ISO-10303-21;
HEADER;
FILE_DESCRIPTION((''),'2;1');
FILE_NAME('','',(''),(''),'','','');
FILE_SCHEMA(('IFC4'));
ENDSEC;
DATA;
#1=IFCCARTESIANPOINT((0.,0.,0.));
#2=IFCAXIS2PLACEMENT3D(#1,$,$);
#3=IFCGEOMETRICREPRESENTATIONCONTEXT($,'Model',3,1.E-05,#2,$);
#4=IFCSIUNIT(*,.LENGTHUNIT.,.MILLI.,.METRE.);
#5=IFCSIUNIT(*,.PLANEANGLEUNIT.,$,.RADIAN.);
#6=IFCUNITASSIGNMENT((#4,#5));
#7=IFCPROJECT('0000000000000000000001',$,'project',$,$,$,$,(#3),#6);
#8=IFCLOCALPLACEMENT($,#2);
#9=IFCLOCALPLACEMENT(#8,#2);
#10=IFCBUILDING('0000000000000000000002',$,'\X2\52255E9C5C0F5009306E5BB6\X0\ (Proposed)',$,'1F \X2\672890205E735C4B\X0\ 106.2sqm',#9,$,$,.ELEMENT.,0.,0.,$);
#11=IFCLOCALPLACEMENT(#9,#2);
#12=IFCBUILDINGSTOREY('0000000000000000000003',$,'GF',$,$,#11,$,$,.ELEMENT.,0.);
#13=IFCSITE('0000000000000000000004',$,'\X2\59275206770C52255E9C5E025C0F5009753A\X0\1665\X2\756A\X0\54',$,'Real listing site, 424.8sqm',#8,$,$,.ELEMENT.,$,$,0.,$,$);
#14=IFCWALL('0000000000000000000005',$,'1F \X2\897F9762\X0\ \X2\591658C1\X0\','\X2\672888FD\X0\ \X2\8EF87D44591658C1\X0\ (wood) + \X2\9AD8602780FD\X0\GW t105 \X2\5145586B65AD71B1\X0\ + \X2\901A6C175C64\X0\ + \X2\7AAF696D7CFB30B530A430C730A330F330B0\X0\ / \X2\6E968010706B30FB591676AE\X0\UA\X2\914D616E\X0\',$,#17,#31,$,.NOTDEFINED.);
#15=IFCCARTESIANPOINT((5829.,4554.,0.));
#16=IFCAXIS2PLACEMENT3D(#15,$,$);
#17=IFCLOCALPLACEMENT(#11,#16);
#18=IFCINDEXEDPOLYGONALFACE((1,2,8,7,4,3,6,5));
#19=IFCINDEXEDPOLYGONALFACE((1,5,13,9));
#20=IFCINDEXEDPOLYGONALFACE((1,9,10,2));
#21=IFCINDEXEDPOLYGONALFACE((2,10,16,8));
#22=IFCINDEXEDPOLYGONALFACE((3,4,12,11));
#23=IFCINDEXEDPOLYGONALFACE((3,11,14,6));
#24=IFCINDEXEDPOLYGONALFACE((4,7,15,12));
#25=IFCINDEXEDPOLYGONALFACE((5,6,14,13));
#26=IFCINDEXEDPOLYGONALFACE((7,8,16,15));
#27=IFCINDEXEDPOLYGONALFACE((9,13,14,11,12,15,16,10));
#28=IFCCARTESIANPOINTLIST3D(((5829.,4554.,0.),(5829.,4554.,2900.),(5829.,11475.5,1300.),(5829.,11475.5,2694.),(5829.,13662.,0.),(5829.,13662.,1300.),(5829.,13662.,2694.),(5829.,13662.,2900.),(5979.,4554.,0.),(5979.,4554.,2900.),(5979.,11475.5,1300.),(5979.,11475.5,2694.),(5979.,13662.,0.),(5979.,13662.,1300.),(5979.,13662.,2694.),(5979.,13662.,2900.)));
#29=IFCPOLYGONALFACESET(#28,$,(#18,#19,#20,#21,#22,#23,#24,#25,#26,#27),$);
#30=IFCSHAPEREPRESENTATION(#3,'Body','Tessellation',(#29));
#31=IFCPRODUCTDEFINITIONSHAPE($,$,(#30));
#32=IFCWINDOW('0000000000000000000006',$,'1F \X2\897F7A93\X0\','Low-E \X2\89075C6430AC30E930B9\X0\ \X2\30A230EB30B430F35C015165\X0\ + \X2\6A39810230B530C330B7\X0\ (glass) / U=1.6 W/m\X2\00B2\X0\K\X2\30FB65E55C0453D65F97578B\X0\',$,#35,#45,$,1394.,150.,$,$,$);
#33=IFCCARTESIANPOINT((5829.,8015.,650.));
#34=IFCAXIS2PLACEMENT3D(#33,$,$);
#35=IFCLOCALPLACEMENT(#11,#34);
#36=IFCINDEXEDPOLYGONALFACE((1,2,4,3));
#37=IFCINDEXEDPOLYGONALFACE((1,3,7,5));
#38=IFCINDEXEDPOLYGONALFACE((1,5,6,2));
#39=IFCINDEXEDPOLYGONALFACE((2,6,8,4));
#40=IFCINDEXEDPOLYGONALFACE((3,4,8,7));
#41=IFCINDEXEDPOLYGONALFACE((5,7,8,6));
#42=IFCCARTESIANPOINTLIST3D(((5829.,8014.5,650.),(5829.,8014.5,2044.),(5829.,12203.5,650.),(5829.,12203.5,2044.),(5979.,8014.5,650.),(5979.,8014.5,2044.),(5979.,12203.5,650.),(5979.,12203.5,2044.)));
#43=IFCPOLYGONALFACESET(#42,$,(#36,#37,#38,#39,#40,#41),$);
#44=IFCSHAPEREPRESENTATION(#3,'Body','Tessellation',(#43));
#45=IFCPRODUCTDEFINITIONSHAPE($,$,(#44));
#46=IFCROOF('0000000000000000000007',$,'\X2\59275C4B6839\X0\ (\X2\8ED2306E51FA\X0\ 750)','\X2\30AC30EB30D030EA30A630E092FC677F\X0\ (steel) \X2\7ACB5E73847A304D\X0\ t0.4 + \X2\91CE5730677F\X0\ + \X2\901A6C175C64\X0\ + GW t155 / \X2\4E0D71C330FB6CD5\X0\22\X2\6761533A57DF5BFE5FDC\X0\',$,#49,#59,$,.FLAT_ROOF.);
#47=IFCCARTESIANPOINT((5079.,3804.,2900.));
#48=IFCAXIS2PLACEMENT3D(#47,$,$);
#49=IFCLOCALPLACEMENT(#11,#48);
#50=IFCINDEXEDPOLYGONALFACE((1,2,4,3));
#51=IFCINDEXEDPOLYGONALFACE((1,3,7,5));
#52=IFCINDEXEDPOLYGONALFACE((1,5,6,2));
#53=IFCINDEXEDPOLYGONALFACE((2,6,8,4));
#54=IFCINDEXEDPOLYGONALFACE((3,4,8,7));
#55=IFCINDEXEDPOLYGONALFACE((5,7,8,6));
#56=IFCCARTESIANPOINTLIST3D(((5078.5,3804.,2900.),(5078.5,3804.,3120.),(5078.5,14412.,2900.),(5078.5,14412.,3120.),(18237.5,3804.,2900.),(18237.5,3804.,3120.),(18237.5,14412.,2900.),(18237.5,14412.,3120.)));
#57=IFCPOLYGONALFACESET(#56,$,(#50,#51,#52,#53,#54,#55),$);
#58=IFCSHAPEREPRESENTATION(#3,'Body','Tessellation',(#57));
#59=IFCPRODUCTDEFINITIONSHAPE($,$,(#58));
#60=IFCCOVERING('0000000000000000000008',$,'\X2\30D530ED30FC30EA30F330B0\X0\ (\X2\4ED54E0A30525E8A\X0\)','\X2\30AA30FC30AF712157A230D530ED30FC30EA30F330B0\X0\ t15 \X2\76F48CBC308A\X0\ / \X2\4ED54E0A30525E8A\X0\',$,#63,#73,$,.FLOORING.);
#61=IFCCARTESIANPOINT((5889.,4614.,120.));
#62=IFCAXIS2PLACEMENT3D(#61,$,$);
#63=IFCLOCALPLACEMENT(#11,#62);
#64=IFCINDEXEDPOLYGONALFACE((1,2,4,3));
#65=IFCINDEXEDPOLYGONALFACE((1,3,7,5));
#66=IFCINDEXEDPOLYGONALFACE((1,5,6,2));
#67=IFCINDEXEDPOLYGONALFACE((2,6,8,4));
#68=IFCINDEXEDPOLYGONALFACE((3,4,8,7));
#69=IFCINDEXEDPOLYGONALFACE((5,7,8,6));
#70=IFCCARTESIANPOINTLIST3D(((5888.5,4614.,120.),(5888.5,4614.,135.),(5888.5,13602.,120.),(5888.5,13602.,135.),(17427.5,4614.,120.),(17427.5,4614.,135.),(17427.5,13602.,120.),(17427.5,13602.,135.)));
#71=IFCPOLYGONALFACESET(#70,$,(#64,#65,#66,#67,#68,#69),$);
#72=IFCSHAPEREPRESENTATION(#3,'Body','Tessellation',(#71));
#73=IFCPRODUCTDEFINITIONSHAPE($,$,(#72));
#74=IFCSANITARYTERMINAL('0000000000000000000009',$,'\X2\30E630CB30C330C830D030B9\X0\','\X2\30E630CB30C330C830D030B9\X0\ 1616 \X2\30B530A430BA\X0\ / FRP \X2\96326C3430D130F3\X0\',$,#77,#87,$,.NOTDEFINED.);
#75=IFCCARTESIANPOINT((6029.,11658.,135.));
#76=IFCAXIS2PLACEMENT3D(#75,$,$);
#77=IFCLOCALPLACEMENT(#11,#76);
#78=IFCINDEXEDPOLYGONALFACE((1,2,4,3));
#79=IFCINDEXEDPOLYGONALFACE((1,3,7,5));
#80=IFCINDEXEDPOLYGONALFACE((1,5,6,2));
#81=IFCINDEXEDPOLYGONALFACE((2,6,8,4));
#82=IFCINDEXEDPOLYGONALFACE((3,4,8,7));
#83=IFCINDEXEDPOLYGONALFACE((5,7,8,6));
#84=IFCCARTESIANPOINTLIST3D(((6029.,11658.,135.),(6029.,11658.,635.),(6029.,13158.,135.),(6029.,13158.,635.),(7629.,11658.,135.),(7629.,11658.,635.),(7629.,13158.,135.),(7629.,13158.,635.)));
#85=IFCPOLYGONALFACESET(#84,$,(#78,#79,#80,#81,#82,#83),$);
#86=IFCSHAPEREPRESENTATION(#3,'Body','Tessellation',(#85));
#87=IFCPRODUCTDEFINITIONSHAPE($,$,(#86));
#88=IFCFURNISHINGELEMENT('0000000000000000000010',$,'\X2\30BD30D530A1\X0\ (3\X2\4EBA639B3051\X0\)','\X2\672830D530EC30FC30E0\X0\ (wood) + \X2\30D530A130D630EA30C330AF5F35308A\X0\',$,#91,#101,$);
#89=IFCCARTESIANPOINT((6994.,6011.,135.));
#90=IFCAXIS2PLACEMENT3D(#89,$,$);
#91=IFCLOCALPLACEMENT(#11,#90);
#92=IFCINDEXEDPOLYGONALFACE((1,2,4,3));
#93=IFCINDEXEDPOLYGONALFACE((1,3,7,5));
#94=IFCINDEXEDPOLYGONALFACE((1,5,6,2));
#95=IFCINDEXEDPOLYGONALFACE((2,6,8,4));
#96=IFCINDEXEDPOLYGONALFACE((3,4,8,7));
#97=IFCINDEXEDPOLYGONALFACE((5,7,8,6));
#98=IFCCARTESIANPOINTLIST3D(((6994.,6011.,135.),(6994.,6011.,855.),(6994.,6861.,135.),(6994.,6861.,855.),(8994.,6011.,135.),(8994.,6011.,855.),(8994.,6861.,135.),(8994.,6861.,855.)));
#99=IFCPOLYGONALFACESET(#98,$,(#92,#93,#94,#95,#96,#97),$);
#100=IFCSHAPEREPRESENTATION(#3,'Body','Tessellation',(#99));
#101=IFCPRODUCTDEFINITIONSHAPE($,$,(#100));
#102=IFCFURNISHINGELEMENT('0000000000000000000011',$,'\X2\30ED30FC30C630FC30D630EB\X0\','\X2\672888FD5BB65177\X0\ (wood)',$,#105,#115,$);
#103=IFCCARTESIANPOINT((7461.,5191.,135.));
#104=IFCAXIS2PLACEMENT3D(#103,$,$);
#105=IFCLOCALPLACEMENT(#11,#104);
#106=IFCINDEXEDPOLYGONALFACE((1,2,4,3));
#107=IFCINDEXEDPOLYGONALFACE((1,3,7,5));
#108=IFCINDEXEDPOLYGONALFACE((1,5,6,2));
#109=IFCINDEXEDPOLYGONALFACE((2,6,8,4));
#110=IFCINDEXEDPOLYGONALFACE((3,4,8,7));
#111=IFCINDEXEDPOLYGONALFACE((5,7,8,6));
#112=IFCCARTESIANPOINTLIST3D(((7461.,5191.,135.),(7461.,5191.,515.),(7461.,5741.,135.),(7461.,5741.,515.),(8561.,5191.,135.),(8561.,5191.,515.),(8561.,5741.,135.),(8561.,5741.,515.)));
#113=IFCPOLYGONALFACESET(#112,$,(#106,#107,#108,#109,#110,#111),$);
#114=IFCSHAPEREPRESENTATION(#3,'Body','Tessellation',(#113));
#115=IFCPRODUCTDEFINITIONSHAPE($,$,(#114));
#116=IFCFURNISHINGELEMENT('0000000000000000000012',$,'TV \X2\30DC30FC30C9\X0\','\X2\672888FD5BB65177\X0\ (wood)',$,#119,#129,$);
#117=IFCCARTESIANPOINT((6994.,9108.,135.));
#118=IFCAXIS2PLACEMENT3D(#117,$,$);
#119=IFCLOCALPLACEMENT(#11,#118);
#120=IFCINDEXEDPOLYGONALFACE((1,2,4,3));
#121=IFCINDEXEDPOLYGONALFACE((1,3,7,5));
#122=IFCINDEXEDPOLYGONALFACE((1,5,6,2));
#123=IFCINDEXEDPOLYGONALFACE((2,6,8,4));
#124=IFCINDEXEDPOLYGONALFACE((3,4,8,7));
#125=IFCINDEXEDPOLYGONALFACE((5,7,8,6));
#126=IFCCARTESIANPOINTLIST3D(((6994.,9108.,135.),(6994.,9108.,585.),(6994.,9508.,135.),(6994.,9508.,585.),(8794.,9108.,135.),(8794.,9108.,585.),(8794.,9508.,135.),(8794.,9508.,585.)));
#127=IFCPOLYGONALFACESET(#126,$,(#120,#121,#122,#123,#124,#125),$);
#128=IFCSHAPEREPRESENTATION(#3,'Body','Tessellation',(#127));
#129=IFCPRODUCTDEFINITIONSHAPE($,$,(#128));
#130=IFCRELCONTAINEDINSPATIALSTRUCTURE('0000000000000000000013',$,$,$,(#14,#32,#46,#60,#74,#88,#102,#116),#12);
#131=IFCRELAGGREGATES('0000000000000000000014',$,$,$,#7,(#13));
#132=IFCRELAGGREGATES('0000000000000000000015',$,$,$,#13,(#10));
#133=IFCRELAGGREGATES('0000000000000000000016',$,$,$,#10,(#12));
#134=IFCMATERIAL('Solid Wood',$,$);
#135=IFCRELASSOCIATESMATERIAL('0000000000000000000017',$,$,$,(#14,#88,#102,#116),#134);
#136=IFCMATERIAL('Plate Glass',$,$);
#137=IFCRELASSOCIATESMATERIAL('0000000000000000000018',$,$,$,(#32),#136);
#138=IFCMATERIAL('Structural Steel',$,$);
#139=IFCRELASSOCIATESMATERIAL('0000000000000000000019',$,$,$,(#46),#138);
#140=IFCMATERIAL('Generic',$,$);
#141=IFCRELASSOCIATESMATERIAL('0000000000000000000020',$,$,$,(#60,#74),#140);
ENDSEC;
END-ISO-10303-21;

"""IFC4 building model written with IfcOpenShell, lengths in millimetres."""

from ifc_helpers import new_model, si_unit, frame, frame_2d, origin, place, context, project, spatial, rectangle, extrude, material, element, fill, save


model = new_model("IFC4")

# Units and contexts
model_context = context("Model", 3, precision=1e-05, world=origin())
ifc_project = project(units=[si_unit("LENGTHUNIT", "METRE", prefix="MILLI"), si_unit("PLANEANGLEUNIT", "RADIAN")], contexts=[model_context])

# Site, building, storey
site_placement = place(None, origin())
site = spatial("IfcSite", under=ifc_project, at=site_placement, Name="大分県別府市小倉町1665番54", ObjectType="Real listing site, 424.8sqm", CompositionType="ELEMENT", RefElevation=0.0)
building_placement = place(site_placement, origin())
building = spatial("IfcBuilding", under=site, at=building_placement, Name="別府小倉の家 (Proposed)", ObjectType="1F 木造平屋 106.2sqm", CompositionType="ELEMENT", ElevationOfRefHeight=0.0, ElevationOfTerrain=0.0)
storey_placement = place(building_placement, origin())
storey = spatial("IfcBuildingStorey", under=building, at=storey_placement, Name="GF", CompositionType="ELEMENT", Elevation=0.0)

# Shared definitions
ifc_material_1 = material(Name="Solid Wood")

# Shared definitions
ifc_material_2 = material(Name="Plate Glass")

# Wall, opening, window
wall_1_placement = place(storey_placement, frame((5829.0, 4554.0, 0.0)))
wall_1 = element("IfcWall", 1, at=wall_1_placement, inside=storey, material=ifc_material_1, Name="1F 西面 外壁", Description="木製 軸組外壁 (wood) + 高性能GW t105 充填断熱 + 通気層 + 窯業系サイディング / 準耐火・外皮UA配慮", PredefinedType="NOTDEFINED", context=model_context, shape_type="SweptSolid", body=[
    extrude(rectangle(XDim=150.0, YDim=9108.0, at=frame_2d((75.0, 4554.0))), frame((5829.0, 4554.0, 0.0)), (0.0, 0.0, 1.0), 2900.0),
])
opening_1_placement = place(storey_placement, frame((5829.0, 8015.0, 650.0)))
opening_1 = element("IfcOpeningElement", 2, at=opening_1_placement, cuts=wall_1, PredefinedType="NOTDEFINED", context=model_context, shape_type="SweptSolid", body=[
    extrude(rectangle(XDim=150.0, YDim=4189.0, at=frame_2d((75.0, 2094.0))), frame((5829.0, 8015.0, 650.0)), (0.0, 0.0, 1.0), 1394.0),
])
window_1_placement = place(storey_placement, frame((5829.0, 8015.0, 650.0)))
window_1 = element("IfcWindow", 3, at=window_1_placement, inside=storey, material=ifc_material_2, Name="1F 西窓", Description="Low-E 複層ガラス アルゴン封入 + 樹脂サッシ (glass) / U=1.6 W/m²K・日射取得型", OverallHeight=1394.0, OverallWidth=150.0, context=model_context, shape_type="SweptSolid", body=[
    extrude(rectangle(XDim=150.0, YDim=4189.0, at=frame_2d((75.0, 2094.0))), frame((5829.0, 8015.0, 650.0)), (0.0, 0.0, 1.0), 1394.0),
])
fill(opening_1, window_1)

# Roof
ifc_material_3 = material(Name="Structural Steel")
roof_placement = place(storey_placement, frame((5079.0, 3804.0, 2900.0)))
element("IfcRoof", 4, at=roof_placement, inside=storey, material=ifc_material_3, Name="大屋根 (軒の出 750)", Description="ガルバリウム鋼板 (steel) 立平葺き t0.4 + 野地板 + 通気層 + GW t155 / 不燃・法22条区域対応", PredefinedType="FLAT_ROOF", context=model_context, shape_type="SweptSolid", body=[
    extrude(rectangle(XDim=13159.0, YDim=10608.0, at=frame_2d((6579.0, 5304.0))), frame((5079.0, 3804.0, 2900.0)), (0.0, 0.0, 1.0), 220.0),
])

# Covering
ifc_material_4 = material(Name="Generic")
covering_placement = place(storey_placement, frame((5889.0, 4614.0, 120.0)))
element("IfcCovering", 5, at=covering_placement, inside=storey, material=ifc_material_4, Name="フローリング (仕上げ床)", Description="オーク無垢フローリング t15 直貼り / 仕上げ床", PredefinedType="FLOORING", context=model_context, shape_type="SweptSolid", body=[
    extrude(rectangle(XDim=11539.0, YDim=8988.0, at=frame_2d((5769.0, 4494.0))), frame((5889.0, 4614.0, 120.0)), (0.0, 0.0, 1.0), 15.0),
])

# Sanitary terminal
sanitary_terminal_placement = place(storey_placement, frame((6029.0, 11658.0, 135.0)))
element("IfcSanitaryTerminal", 6, at=sanitary_terminal_placement, inside=storey, material=ifc_material_4, Name="ユニットバス", Description="ユニットバス 1616 サイズ / FRP 防水パン", PredefinedType="NOTDEFINED", context=model_context, shape_type="SweptSolid", body=[
    extrude(rectangle(XDim=1600.0, YDim=1500.0, at=frame_2d((800.0, 750.0))), frame((6029.0, 11658.0, 135.0)), (0.0, 0.0, 1.0), 500.0),
])

# Furnishing elements
furnishing_1_placement = place(storey_placement, frame((6994.0, 6011.0, 135.0)))
element("IfcFurnishingElement", 7, at=furnishing_1_placement, inside=storey, material=ifc_material_1, Name="ソファ (3人掛け)", Description="木フレーム (wood) + ファブリック張り", context=model_context, shape_type="SweptSolid", body=[
    extrude(rectangle(XDim=2000.0, YDim=850.0, at=frame_2d((1000.0, 425.0))), frame((6994.0, 6011.0, 135.0)), (0.0, 0.0, 1.0), 720.0),
])
furnishing_2_placement = place(storey_placement, frame((7461.0, 5191.0, 135.0)))
element("IfcFurnishingElement", 8, at=furnishing_2_placement, inside=storey, material=ifc_material_1, Name="ローテーブル", Description="木製家具 (wood)", context=model_context, shape_type="SweptSolid", body=[
    extrude(rectangle(XDim=1100.0, YDim=550.0, at=frame_2d((550.0, 275.0))), frame((7461.0, 5191.0, 135.0)), (0.0, 0.0, 1.0), 380.0),
])
furnishing_3_placement = place(storey_placement, frame((6994.0, 9108.0, 135.0)))
element("IfcFurnishingElement", 9, at=furnishing_3_placement, inside=storey, material=ifc_material_1, Name="TV ボード", Description="木製家具 (wood)", context=model_context, shape_type="SweptSolid", body=[
    extrude(rectangle(XDim=1800.0, YDim=400.0, at=frame_2d((900.0, 200.0))), frame((6994.0, 9108.0, 135.0)), (0.0, 0.0, 1.0), 450.0),
])

save(model, "model.ifc")
